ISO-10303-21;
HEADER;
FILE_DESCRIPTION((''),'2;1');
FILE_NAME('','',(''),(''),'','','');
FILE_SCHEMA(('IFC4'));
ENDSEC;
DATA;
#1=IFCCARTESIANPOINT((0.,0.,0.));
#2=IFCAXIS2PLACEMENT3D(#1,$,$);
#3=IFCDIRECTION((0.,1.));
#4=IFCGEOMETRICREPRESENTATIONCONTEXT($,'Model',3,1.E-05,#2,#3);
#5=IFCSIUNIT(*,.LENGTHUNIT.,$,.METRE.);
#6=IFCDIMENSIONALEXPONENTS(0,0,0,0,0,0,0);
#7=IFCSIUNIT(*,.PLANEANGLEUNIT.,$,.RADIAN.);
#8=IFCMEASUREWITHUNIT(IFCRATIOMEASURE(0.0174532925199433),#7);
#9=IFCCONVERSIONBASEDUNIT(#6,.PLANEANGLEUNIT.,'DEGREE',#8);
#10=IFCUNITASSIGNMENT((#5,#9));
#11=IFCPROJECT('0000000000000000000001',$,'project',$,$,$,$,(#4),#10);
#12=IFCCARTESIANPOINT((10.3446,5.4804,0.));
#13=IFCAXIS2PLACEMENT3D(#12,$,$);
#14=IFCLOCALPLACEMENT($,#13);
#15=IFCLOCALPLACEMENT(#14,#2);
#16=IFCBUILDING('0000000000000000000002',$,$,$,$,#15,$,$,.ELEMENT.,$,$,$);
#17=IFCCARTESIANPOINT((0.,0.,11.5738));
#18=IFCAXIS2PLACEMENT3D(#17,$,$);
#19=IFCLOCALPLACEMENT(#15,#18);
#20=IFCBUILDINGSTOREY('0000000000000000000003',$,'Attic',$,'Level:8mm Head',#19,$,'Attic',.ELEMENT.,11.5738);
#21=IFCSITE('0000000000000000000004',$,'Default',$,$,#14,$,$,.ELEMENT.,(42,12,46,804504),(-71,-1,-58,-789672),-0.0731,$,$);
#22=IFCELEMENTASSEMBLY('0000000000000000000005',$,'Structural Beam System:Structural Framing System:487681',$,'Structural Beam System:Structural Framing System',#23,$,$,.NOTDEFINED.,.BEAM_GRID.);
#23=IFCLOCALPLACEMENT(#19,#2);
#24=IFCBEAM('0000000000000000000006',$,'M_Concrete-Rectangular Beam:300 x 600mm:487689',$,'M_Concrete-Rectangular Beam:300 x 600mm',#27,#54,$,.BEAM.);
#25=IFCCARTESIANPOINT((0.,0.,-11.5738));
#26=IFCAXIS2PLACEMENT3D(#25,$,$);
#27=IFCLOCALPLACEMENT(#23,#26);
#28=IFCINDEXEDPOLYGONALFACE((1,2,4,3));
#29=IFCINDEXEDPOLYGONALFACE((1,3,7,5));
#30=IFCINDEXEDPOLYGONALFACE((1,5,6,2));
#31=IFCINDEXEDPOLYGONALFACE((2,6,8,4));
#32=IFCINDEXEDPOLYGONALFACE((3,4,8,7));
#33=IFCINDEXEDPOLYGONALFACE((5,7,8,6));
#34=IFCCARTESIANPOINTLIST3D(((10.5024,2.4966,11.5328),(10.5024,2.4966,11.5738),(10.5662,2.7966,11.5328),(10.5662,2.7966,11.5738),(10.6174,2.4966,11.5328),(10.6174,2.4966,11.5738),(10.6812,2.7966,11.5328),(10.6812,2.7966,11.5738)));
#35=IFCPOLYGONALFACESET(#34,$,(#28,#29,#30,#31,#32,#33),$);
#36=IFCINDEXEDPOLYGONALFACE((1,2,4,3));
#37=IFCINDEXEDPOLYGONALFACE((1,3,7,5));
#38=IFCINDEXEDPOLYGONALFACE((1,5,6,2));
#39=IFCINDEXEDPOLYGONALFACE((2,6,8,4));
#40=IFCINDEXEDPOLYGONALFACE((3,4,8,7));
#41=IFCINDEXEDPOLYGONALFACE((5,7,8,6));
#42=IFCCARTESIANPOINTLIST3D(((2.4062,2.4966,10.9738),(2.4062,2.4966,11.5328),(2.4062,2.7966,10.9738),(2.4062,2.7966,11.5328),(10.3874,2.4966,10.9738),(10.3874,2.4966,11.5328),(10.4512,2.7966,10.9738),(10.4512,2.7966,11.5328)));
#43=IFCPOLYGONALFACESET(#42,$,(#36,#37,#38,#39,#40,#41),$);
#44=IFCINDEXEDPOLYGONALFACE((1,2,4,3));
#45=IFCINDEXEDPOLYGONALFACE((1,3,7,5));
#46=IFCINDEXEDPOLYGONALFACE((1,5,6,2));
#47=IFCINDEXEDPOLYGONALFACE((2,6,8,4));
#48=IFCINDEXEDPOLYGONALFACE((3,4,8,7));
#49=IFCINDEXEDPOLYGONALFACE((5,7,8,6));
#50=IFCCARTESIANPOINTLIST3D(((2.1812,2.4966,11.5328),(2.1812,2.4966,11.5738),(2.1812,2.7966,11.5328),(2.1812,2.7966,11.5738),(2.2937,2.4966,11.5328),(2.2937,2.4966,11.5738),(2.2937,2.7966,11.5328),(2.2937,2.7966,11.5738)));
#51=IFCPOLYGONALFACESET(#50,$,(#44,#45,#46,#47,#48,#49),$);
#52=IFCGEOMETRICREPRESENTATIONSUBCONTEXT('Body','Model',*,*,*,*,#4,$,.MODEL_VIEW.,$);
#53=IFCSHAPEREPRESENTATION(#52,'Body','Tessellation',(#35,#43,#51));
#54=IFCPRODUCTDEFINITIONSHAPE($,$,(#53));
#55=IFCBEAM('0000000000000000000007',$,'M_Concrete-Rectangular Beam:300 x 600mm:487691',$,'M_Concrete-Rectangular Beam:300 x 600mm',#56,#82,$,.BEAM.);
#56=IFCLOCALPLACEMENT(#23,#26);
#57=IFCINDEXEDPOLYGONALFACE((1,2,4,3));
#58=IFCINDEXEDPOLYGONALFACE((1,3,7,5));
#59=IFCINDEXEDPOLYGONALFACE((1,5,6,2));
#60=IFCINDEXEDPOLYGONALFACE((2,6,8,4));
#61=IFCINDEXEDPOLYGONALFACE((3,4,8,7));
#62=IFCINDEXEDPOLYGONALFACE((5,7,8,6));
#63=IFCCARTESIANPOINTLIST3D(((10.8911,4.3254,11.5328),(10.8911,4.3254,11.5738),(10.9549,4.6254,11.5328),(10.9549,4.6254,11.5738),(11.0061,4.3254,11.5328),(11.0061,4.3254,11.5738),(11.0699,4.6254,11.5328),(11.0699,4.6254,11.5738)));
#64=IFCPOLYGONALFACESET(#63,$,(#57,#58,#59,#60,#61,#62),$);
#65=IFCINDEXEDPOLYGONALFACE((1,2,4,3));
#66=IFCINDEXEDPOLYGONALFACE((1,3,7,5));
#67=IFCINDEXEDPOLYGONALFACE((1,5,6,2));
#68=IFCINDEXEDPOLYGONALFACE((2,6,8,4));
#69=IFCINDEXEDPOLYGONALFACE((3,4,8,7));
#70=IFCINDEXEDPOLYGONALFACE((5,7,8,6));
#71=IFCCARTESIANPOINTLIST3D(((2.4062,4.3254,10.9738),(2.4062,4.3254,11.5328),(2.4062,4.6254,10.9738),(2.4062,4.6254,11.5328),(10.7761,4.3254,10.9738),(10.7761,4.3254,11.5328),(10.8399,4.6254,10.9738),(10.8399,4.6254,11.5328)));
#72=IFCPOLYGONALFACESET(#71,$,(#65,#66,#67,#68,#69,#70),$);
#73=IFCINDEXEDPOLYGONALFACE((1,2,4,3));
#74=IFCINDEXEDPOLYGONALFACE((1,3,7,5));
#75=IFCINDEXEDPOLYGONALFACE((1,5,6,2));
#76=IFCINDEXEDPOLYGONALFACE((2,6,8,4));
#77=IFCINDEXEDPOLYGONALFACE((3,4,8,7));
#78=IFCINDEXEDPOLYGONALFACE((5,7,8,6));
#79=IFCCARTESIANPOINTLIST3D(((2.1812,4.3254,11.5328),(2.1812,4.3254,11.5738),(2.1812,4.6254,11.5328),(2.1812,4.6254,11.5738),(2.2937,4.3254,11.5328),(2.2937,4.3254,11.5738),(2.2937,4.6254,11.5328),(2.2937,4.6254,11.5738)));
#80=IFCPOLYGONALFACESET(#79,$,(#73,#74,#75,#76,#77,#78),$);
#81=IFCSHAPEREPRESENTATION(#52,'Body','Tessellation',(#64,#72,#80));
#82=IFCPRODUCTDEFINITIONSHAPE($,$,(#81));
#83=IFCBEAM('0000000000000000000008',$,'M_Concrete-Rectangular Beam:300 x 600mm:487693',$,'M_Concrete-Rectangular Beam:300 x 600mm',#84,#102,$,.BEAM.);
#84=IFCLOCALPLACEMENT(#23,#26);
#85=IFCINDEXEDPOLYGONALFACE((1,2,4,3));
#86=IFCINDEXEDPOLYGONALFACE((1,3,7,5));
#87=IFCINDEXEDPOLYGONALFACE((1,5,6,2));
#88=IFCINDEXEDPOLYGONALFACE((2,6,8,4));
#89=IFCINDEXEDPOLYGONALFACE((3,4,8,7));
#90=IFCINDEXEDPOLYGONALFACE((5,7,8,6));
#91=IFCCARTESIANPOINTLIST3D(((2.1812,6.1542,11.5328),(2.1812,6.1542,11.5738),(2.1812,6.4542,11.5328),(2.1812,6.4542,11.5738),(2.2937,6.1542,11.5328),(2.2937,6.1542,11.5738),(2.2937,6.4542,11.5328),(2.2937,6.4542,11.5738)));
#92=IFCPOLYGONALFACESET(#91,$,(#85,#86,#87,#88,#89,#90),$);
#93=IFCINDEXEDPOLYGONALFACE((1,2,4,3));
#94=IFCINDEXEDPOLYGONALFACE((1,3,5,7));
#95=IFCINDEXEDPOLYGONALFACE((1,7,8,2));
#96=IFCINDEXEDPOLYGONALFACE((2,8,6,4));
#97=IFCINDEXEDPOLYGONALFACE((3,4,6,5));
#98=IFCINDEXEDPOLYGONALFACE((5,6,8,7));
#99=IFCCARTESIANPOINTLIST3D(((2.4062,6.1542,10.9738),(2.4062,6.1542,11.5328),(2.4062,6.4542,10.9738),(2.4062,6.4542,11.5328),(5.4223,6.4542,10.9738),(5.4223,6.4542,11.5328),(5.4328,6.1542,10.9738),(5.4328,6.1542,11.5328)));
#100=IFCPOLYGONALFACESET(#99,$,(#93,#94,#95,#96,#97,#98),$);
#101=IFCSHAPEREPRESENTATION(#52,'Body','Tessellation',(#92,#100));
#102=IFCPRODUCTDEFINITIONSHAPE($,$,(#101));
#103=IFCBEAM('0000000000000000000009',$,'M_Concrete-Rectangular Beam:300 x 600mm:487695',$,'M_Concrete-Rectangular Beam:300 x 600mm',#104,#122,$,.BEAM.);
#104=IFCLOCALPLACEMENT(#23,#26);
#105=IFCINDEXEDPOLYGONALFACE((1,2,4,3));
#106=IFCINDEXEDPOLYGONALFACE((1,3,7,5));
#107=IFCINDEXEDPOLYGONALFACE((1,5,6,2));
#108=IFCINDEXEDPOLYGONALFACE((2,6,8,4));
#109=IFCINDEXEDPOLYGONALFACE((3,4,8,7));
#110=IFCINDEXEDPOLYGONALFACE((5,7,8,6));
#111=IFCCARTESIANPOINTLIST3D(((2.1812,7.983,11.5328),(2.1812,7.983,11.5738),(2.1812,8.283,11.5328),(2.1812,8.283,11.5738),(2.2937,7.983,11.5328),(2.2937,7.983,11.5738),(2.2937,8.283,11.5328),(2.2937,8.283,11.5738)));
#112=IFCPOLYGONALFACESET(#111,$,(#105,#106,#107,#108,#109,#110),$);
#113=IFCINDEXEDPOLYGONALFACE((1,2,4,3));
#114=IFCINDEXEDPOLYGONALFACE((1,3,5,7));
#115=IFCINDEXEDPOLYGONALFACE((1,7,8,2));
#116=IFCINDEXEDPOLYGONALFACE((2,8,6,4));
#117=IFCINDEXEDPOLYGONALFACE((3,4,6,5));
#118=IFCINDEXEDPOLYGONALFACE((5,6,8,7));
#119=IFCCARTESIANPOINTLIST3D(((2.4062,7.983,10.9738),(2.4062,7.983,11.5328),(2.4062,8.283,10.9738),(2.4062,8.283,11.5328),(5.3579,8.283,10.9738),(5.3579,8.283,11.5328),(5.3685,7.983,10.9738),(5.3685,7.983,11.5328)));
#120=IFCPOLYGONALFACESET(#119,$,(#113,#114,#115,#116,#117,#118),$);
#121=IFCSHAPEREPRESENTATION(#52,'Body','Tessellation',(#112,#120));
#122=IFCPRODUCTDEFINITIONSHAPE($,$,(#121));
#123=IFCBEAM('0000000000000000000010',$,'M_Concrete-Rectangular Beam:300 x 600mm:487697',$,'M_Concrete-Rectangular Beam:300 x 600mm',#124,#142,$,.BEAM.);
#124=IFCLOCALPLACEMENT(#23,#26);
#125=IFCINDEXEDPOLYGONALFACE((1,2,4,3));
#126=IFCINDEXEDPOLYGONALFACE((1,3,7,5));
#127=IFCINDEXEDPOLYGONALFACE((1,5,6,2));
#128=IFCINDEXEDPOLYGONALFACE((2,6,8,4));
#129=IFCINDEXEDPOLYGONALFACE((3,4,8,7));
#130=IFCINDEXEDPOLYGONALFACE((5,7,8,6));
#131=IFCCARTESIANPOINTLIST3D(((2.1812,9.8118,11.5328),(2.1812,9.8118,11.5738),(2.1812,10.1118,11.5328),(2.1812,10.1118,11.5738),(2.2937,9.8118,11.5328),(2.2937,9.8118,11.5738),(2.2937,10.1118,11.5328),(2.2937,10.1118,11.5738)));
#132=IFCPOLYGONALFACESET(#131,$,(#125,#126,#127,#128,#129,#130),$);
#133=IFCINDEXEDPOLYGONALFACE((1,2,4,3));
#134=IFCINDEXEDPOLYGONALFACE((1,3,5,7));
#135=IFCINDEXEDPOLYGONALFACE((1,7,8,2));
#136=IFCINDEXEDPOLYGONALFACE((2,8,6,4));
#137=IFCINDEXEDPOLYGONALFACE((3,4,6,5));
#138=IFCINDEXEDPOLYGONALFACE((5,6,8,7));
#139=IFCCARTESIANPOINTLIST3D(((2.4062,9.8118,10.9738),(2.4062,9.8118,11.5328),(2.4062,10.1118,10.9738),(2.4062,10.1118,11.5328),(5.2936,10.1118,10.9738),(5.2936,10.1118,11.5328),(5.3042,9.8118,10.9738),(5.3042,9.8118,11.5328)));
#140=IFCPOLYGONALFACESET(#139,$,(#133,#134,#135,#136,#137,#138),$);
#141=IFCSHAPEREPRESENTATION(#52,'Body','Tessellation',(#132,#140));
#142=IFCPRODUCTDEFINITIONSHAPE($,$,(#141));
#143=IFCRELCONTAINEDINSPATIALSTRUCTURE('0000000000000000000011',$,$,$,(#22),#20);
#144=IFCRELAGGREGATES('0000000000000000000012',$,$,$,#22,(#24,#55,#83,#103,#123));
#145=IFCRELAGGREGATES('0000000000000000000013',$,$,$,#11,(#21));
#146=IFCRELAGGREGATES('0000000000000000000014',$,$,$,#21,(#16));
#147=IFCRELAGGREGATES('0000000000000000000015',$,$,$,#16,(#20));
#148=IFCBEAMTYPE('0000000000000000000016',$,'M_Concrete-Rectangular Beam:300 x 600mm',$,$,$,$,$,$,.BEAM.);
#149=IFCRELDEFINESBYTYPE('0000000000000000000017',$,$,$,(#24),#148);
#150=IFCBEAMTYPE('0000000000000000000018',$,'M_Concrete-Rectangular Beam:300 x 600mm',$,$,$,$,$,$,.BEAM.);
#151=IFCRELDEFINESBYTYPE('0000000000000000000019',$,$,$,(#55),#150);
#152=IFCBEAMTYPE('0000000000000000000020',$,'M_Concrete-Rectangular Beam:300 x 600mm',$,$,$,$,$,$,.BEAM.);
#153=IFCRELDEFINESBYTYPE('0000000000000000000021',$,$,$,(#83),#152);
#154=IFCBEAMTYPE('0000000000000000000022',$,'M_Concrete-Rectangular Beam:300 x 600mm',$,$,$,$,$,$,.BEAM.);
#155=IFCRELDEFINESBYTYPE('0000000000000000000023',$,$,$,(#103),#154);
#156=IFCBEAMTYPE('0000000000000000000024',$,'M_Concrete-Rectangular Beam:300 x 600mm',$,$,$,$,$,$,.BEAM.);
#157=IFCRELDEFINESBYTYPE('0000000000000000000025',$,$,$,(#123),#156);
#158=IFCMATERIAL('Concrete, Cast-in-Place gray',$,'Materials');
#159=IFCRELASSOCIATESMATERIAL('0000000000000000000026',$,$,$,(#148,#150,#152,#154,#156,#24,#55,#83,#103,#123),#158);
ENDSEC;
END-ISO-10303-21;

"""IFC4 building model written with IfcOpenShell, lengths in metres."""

from ifc_helpers import new_model, entity, si_unit, converted_unit, direction, frame, frame_2d, origin, place, context, subcontext, project, spatial, rectangle, extrude, clip, halfspace, source, transform, mapped, material, material_profile, profile_set, profile_usage, type_object, type_shapes, element, aggregate, save


model = new_model("IFC4")

# Units and contexts
model_context = context("Model", 3, precision=1e-05, world=origin(), true_north=direction((0.0, 1.0)))
body_context = subcontext(model_context, "Body", "Model", "MODEL_VIEW")
ifc_project = project(units=[si_unit("LENGTHUNIT", "METRE"), converted_unit("PLANEANGLEUNIT", "DEGREE", entity("IfcRatioMeasure", 0.0174532925199433), si_unit("PLANEANGLEUNIT", "RADIAN"), dimensions=[0, 0, 0, 0, 0, 0, 0])], contexts=[model_context])

# Site, building, storey
site_placement = place(None, frame((10.3446, 5.4804, 0.0)))
site = spatial("IfcSite", under=ifc_project, at=site_placement, Name="Default", CompositionType="ELEMENT", RefLatitude=(42, 12, 46, 804504), RefLongitude=(-71, -1, -58, -789672), RefElevation=-0.0731)
building_placement = place(site_placement, origin())
building = spatial("IfcBuilding", under=site, at=building_placement, CompositionType="ELEMENT")
storey_placement = place(building_placement, frame((0.0, 0.0, 11.5738)))
storey = spatial("IfcBuildingStorey", under=building, at=storey_placement, Name="Attic", ObjectType="Level:8mm Head", LongName="Attic", CompositionType="ELEMENT", Elevation=11.5738)

# Element assembly, beams
ifc_material_1 = material(Name="Concrete, Cast-in-Place gray", Category="Materials")
ifc_material_profile = material_profile(ifc_material_1, rectangle(XDim=0.559, YDim=0.3, at=frame_2d((0.0, 0.0), x_axis=(1.0, 0.0))), Name="300 x 600mm")
ifc_profile_set = profile_set([ifc_material_profile], Name="300 x 600mm")
assembly_1_placement = place(storey_placement, origin())
assembly_1 = element("IfcElementAssembly", 1, at=assembly_1_placement, inside=storey, Name="Structural Beam System:Structural Framing System:487681", ObjectType="Structural Beam System:Structural Framing System", AssemblyPlace="NOTDEFINED", PredefinedType="BEAM_GRID")
ifc_profile_usage_1 = profile_usage(ifc_profile_set, cardinal=8)
beam_type_1 = type_object("IfcBeamType", Name="M_Concrete-Rectangular Beam:300 x 600mm", PredefinedType="BEAM", material=ifc_profile_set)
shared_shape_1 = source(origin(), body_context, "Body", "SweptSolid", [
    clip(clip(extrude(rectangle(XDim=0.041, YDim=0.3, at=frame_2d((0.0, 0.0), x_axis=(1.0, 0.0))), frame((10.6812, 2.6466, 11.5533), z_axis=(-1.0, 0.0, 0.0), x_axis=(0.0, 0.0, -1.0)), (0.0, 0.0, 1.0), 0.1788), halfspace(frame((12.1762, 10.3713, 11.5328), z_axis=(-0.978148, 0.207912, 0.0), x_axis=(0.0, 0.0, 1.0)), False)), halfspace(frame((10.6058, 2.4418, 11.9447), z_axis=(0.978148, -0.207912, 0.0), x_axis=(0.207912, 0.978148, 0.0)), False)),
    clip(extrude(rectangle(XDim=0.559, YDim=0.3, at=frame_2d((0.0, 0.0), x_axis=(1.0, 0.0))), frame((10.4512, 2.6466, 11.2533), z_axis=(-1.0, 0.0, 0.0), x_axis=(0.0, 0.0, -1.0)), (0.0, 0.0, 1.0), 8.045), halfspace(frame((8.6968, -5.457, 8.1531), z_axis=(0.978148, -0.207912, 0.0), x_axis=(-0.207912, -0.978148, 0.0)), False)),
    extrude(rectangle(XDim=0.041, YDim=0.3, at=frame_2d((0.0, 0.0), x_axis=(1.0, 0.0))), frame((2.2937, 2.6466, 11.5533), z_axis=(-1.0, 0.0, 0.0), x_axis=(0.0, 0.0, -1.0)), (0.0, 0.0, 1.0), 0.1125),
])
type_shapes(beam_type_1, [shared_shape_1])
beam_1_placement = place(assembly_1_placement, frame((0.0, 0.0, -11.5738)))
beam_1 = element("IfcBeam", 2, at=beam_1_placement, type_object=beam_type_1, material=ifc_profile_usage_1, Name="M_Concrete-Rectangular Beam:300 x 600mm:487689", ObjectType="M_Concrete-Rectangular Beam:300 x 600mm", PredefinedType="BEAM", context=body_context, shape_type="MappedRepresentation", body=[
    mapped(shared_shape_1, transform((0.0, 0.0, 0.0), scale=1.0)),
])
ifc_profile_usage_2 = profile_usage(ifc_profile_set, cardinal=8)
beam_type_2 = type_object("IfcBeamType", Name="M_Concrete-Rectangular Beam:300 x 600mm", PredefinedType="BEAM", material=ifc_profile_set)
shared_shape_2 = source(origin(), body_context, "Body", "SweptSolid", [
    clip(clip(extrude(rectangle(XDim=0.041, YDim=0.3, at=frame_2d((0.0, 0.0), x_axis=(1.0, 0.0))), frame((11.0699, 4.4754, 11.5533), z_axis=(-1.0, 0.0, 0.0), x_axis=(0.0, 0.0, -1.0)), (0.0, 0.0, 1.0), 0.1788), halfspace(frame((12.1762, 10.3713, 11.5328), z_axis=(-0.978148, 0.207912, 0.0), x_axis=(0.0, 0.0, 1.0)), False)), halfspace(frame((10.9945, 4.2706, 11.9447), z_axis=(0.978148, -0.207912, 0.0), x_axis=(0.207912, 0.978148, 0.0)), False)),
    clip(extrude(rectangle(XDim=0.559, YDim=0.3, at=frame_2d((0.0, 0.0), x_axis=(1.0, 0.0))), frame((10.8399, 4.4754, 11.2533), z_axis=(-1.0, 0.0, 0.0), x_axis=(0.0, 0.0, -1.0)), (0.0, 0.0, 1.0), 8.4337), halfspace(frame((8.6968, -5.457, 8.1531), z_axis=(0.978148, -0.207912, 0.0), x_axis=(-0.207912, -0.978148, 0.0)), False)),
    extrude(rectangle(XDim=0.041, YDim=0.3, at=frame_2d((0.0, 0.0), x_axis=(1.0, 0.0))), frame((2.2937, 4.4754, 11.5533), z_axis=(-1.0, 0.0, 0.0), x_axis=(0.0, 0.0, -1.0)), (0.0, 0.0, 1.0), 0.1125),
])
type_shapes(beam_type_2, [shared_shape_2])
beam_2_placement = place(assembly_1_placement, frame((0.0, 0.0, -11.5738)))
beam_2 = element("IfcBeam", 3, at=beam_2_placement, type_object=beam_type_2, material=ifc_profile_usage_2, Name="M_Concrete-Rectangular Beam:300 x 600mm:487691", ObjectType="M_Concrete-Rectangular Beam:300 x 600mm", PredefinedType="BEAM", context=body_context, shape_type="MappedRepresentation", body=[
    mapped(shared_shape_2, transform((0.0, 0.0, 0.0), scale=1.0)),
])
ifc_profile_usage_3 = profile_usage(ifc_profile_set, cardinal=8)
beam_type_3 = type_object("IfcBeamType", Name="M_Concrete-Rectangular Beam:300 x 600mm", PredefinedType="BEAM", material=ifc_profile_set)
shared_shape_3 = source(origin(), body_context, "Body", "SweptSolid", [
    extrude(rectangle(XDim=0.041, YDim=0.3, at=frame_2d((0.0, 0.0), x_axis=(1.0, 0.0))), frame((2.2937, 6.3042, 11.5533), z_axis=(-1.0, 0.0, 0.0), x_axis=(0.0, 0.0, -1.0)), (0.0, 0.0, 1.0), 0.1125),
    clip(extrude(rectangle(XDim=0.559, YDim=0.3, at=frame_2d((0.0, 0.0), x_axis=(1.0, 0.0))), frame((5.4328, 6.3042, 11.2533), z_axis=(-1.0, 0.0, 0.0), x_axis=(0.0, 0.0, -1.0)), (0.0, 0.0, 1.0), 3.0267), halfspace(frame((5.451, 5.6393, 8.1531), z_axis=(0.999382, 0.035159, 0.0), x_axis=(0.035159, -0.999382, 0.0)), False)),
])
type_shapes(beam_type_3, [shared_shape_3])
beam_3_placement = place(assembly_1_placement, frame((0.0, 0.0, -11.5738)))
beam_3 = element("IfcBeam", 4, at=beam_3_placement, type_object=beam_type_3, material=ifc_profile_usage_3, Name="M_Concrete-Rectangular Beam:300 x 600mm:487693", ObjectType="M_Concrete-Rectangular Beam:300 x 600mm", PredefinedType="BEAM", context=body_context, shape_type="MappedRepresentation", body=[
    mapped(shared_shape_3, transform((0.0, 0.0, 0.0), scale=1.0)),
])
ifc_profile_usage_4 = profile_usage(ifc_profile_set, cardinal=8)
beam_type_4 = type_object("IfcBeamType", Name="M_Concrete-Rectangular Beam:300 x 600mm", PredefinedType="BEAM", material=ifc_profile_set)
shared_shape_4 = source(origin(), body_context, "Body", "SweptSolid", [
    extrude(rectangle(XDim=0.041, YDim=0.3, at=frame_2d((0.0, 0.0), x_axis=(1.0, 0.0))), frame((2.2937, 8.133, 11.5533), z_axis=(-1.0, 0.0, 0.0), x_axis=(0.0, 0.0, -1.0)), (0.0, 0.0, 1.0), 0.1125),
    clip(extrude(rectangle(XDim=0.559, YDim=0.3, at=frame_2d((0.0, 0.0), x_axis=(1.0, 0.0))), frame((5.3685, 8.133, 11.2533), z_axis=(-1.0, 0.0, 0.0), x_axis=(0.0, 0.0, -1.0)), (0.0, 0.0, 1.0), 2.9623), halfspace(frame((5.451, 5.6393, 8.1531), z_axis=(0.999382, 0.035159, 0.0), x_axis=(0.035159, -0.999382, 0.0)), False)),
])
type_shapes(beam_type_4, [shared_shape_4])
beam_4_placement = place(assembly_1_placement, frame((0.0, 0.0, -11.5738)))
beam_4 = element("IfcBeam", 5, at=beam_4_placement, type_object=beam_type_4, material=ifc_profile_usage_4, Name="M_Concrete-Rectangular Beam:300 x 600mm:487695", ObjectType="M_Concrete-Rectangular Beam:300 x 600mm", PredefinedType="BEAM", context=body_context, shape_type="MappedRepresentation", body=[
    mapped(shared_shape_4, transform((0.0, 0.0, 0.0), scale=1.0)),
])
ifc_profile_usage_5 = profile_usage(ifc_profile_set, cardinal=8)
beam_type_5 = type_object("IfcBeamType", Name="M_Concrete-Rectangular Beam:300 x 600mm", PredefinedType="BEAM", material=ifc_profile_set)
shared_shape_5 = source(origin(), body_context, "Body", "SweptSolid", [
    extrude(rectangle(XDim=0.041, YDim=0.3, at=frame_2d((0.0, 0.0), x_axis=(1.0, 0.0))), frame((2.2937, 9.9618, 11.5533), z_axis=(-1.0, 0.0, 0.0), x_axis=(0.0, 0.0, -1.0)), (0.0, 0.0, 1.0), 0.1125),
    clip(extrude(rectangle(XDim=0.559, YDim=0.3, at=frame_2d((0.0, 0.0), x_axis=(1.0, 0.0))), frame((5.3042, 9.9618, 11.2533), z_axis=(-1.0, 0.0, 0.0), x_axis=(0.0, 0.0, -1.0)), (0.0, 0.0, 1.0), 2.898), halfspace(frame((5.451, 5.6393, 8.1531), z_axis=(0.999382, 0.035159, 0.0), x_axis=(0.035159, -0.999382, 0.0)), False)),
])
type_shapes(beam_type_5, [shared_shape_5])
beam_5_placement = place(assembly_1_placement, frame((0.0, 0.0, -11.5738)))
beam_5 = element("IfcBeam", 6, at=beam_5_placement, type_object=beam_type_5, material=ifc_profile_usage_5, Name="M_Concrete-Rectangular Beam:300 x 600mm:487697", ObjectType="M_Concrete-Rectangular Beam:300 x 600mm", PredefinedType="BEAM", context=body_context, shape_type="MappedRepresentation", body=[
    mapped(shared_shape_5, transform((0.0, 0.0, 0.0), scale=1.0)),
])
aggregate(assembly_1, [beam_1, beam_2, beam_3, beam_4, beam_5])

save(model, "model.ifc")
